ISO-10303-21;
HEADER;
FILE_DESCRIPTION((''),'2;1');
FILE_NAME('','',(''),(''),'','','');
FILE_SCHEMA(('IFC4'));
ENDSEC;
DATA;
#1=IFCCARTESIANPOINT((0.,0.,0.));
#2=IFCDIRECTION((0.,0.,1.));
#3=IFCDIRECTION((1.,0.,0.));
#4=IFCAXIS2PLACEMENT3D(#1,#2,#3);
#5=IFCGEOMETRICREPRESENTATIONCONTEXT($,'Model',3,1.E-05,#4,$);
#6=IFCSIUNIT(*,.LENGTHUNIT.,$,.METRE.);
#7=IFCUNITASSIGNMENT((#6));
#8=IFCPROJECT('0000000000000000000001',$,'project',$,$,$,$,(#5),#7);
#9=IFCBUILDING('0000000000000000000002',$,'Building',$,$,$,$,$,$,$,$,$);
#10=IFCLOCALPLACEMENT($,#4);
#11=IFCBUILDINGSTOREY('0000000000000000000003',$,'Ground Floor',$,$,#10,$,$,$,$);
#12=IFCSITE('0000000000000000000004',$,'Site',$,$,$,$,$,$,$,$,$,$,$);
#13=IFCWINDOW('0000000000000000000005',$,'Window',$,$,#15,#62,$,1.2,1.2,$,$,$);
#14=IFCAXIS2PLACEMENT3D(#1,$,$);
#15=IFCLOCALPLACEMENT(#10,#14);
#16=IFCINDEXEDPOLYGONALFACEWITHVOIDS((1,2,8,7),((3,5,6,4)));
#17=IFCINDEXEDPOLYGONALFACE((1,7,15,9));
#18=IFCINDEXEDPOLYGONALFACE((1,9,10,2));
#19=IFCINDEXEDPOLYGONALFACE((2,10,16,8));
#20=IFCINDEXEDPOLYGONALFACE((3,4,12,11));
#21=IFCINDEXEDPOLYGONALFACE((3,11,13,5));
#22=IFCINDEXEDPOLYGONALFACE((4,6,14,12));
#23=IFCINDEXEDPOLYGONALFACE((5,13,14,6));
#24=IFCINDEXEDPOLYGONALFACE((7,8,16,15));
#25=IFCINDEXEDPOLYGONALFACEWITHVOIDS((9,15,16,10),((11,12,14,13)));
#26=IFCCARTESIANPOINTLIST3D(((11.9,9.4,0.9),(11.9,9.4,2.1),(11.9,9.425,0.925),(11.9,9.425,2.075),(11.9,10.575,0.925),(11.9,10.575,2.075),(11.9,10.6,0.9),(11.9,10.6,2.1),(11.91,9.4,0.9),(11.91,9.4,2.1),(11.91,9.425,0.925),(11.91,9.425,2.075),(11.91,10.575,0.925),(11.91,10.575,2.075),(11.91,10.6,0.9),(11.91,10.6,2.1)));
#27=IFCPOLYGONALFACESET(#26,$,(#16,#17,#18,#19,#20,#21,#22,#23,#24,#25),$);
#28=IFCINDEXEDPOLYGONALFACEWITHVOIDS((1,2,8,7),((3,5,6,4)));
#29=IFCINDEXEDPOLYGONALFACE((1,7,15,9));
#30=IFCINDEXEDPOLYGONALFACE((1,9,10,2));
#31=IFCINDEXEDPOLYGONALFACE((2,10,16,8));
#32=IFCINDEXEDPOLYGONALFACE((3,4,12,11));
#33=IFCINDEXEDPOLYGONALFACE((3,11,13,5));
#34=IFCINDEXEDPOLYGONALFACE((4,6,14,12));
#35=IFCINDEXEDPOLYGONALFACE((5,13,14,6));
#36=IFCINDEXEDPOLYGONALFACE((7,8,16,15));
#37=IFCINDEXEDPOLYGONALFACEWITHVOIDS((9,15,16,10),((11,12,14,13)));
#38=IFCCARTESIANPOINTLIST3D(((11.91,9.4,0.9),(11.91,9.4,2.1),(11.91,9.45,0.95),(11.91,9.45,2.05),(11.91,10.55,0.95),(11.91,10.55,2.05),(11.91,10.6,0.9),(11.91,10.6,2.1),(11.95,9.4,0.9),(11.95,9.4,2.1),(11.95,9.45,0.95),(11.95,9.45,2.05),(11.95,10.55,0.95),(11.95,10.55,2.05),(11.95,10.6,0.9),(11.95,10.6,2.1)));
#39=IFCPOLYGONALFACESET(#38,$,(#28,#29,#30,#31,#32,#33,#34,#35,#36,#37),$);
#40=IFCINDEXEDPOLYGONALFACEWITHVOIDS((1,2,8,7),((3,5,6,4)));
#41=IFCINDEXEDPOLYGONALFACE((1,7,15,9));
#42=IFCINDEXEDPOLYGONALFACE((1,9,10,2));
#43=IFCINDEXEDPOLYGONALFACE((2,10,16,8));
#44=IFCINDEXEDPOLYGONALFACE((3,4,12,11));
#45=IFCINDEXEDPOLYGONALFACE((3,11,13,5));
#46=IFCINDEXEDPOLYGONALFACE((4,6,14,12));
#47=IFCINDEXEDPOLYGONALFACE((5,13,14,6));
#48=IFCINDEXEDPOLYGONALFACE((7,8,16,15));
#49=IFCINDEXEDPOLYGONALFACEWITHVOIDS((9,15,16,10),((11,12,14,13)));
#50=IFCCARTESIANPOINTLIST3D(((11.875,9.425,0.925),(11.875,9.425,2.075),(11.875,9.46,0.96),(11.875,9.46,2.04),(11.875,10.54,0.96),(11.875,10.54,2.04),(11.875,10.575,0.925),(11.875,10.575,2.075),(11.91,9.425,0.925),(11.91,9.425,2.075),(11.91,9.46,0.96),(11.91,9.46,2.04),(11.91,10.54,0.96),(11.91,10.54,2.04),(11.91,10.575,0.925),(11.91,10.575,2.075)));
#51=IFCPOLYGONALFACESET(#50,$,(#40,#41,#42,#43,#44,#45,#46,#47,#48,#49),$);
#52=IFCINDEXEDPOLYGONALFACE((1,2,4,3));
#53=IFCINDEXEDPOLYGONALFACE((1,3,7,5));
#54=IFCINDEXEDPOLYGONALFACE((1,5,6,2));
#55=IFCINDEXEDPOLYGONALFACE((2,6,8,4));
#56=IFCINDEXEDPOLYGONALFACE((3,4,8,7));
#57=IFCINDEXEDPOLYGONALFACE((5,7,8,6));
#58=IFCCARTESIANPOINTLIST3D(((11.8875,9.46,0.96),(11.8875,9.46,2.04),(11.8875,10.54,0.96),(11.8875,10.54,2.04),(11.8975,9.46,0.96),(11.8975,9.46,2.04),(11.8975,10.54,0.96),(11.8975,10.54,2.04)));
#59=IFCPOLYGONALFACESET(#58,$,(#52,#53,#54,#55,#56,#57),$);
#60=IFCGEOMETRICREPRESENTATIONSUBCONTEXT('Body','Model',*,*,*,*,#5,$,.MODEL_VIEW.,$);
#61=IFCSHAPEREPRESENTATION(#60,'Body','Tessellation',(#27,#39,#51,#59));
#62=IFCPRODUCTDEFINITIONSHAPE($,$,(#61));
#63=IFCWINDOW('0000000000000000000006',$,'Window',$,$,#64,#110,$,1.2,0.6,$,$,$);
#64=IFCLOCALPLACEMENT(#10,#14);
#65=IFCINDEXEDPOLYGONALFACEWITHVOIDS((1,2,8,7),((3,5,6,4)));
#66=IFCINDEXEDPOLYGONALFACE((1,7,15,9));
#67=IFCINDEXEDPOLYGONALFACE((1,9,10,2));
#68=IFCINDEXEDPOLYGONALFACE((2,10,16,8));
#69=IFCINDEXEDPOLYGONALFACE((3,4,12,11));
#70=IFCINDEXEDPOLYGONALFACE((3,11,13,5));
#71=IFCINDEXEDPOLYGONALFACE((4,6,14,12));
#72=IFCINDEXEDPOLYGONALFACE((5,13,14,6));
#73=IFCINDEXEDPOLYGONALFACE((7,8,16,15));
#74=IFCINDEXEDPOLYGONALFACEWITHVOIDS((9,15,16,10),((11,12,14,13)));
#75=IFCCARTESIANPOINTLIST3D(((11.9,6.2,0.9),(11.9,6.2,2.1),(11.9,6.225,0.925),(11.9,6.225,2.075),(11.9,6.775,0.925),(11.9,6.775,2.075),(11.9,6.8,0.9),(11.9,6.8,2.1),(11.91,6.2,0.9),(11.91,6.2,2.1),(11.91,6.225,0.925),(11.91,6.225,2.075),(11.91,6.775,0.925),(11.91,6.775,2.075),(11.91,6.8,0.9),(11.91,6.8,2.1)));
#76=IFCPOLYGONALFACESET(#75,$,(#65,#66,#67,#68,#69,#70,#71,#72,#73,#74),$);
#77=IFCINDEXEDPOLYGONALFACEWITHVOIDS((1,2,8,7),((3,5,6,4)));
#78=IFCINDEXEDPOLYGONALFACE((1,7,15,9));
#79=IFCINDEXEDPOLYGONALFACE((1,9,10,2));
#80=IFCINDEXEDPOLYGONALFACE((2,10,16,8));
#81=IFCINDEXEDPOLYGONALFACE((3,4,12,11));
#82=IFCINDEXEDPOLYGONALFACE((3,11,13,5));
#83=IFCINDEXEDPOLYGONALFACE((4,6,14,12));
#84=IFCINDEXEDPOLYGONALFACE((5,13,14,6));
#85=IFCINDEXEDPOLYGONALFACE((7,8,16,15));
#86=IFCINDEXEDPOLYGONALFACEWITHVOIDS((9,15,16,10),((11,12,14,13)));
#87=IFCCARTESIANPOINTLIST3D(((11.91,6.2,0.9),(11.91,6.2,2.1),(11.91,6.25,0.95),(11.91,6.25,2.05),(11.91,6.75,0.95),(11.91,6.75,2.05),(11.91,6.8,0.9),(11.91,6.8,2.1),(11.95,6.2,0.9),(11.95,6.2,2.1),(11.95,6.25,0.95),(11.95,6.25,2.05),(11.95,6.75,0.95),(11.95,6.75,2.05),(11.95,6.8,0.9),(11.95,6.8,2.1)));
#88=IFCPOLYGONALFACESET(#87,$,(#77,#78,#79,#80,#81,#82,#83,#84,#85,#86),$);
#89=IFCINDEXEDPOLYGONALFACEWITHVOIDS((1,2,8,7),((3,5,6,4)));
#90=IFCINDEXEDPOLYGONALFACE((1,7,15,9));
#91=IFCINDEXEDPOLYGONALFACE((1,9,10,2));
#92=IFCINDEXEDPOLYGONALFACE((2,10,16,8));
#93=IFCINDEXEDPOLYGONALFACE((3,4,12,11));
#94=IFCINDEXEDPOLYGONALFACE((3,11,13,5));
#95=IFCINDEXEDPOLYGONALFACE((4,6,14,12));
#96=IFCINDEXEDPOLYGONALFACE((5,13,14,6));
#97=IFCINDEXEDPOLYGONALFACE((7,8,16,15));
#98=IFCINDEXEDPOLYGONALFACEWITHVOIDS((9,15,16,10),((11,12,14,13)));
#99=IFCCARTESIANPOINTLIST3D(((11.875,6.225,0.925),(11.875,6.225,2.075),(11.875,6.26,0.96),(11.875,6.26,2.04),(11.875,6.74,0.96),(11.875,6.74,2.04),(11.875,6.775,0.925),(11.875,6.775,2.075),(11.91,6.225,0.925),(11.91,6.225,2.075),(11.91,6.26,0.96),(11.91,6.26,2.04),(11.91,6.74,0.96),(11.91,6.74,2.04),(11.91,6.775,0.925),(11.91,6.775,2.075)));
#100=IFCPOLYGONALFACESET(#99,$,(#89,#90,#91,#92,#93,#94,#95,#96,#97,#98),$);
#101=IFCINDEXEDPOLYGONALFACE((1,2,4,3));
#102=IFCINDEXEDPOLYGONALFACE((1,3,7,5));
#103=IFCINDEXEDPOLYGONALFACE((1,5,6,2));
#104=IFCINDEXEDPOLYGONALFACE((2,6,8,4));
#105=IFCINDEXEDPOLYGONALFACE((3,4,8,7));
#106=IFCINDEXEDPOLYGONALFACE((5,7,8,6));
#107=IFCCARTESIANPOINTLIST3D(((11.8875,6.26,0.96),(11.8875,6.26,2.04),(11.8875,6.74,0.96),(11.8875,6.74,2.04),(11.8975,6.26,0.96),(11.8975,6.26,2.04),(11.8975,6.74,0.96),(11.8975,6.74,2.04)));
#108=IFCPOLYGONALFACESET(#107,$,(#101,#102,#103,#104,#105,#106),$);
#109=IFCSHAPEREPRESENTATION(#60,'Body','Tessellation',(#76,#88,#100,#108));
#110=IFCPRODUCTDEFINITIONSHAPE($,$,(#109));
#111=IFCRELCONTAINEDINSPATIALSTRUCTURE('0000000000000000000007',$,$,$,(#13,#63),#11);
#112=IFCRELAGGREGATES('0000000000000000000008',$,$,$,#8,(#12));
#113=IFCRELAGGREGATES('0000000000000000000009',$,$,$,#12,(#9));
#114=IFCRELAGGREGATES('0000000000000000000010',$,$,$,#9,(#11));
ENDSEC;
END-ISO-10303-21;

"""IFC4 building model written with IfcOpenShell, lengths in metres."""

from ifc_helpers import new_model, si_unit, frame, origin_with_axes, place, context, subcontext, project, spatial, line, indexed_curve, outline, extrude, element, save


model = new_model("IFC4")

# Units and contexts
model_context = context("Model", 3, precision=1e-05, world=origin_with_axes())
body_context = subcontext(model_context, "Body", "Model", "MODEL_VIEW")
ifc_project = project(units=[si_unit("LENGTHUNIT", "METRE")], contexts=[model_context])

# Site, building, storey
site = spatial("IfcSite", under=ifc_project, Name="Site")
building = spatial("IfcBuilding", under=site, Name="Building")
storey_placement = place(None, origin_with_axes())
storey = spatial("IfcBuildingStorey", under=building, at=storey_placement, Name="Ground Floor")

# Windows
for number, where, z_axis, x_axis, name in (
    (1, (12.0, 9.4, 0.9), (0.0, 0.0, 1.0), (0.0, 1.0, 0.0), "Window"),
):
    element("IfcWindow", number, at=place(storey_placement, frame(where, z_axis=z_axis, x_axis=x_axis)), inside=storey, Name=name, OverallHeight=1.2, OverallWidth=1.2, context=body_context, shape_type="SweptSolid", body=[
        extrude(outline(indexed_curve([(0.0, 0.0), (1.2, 0.0), (1.2, 1.2), (0.0, 1.2)], segments=[line(1, 2, 3, 4, 1)]), holes=[indexed_curve([(0.025, 0.025), (1.175, 0.025), (1.175, 1.175), (0.025, 1.175)], segments=[line(1, 2, 3, 4, 1)])]), frame((0.0, 0.09, 0.0), z_axis=(0.0, -1.0, 0.0), x_axis=(1.0, 0.0, 0.0)), (0.0, 0.0, -1.0), 0.01),
        extrude(outline(indexed_curve([(0.0, 0.0), (1.2, 0.0), (1.2, 1.2), (0.0, 1.2)], segments=[line(1, 2, 3, 4, 1)]), holes=[indexed_curve([(0.05, 0.05), (1.15, 0.05), (1.15, 1.15), (0.05, 1.15)], segments=[line(1, 2, 3, 4, 1)])]), frame((0.0, 0.05, 0.0), z_axis=(0.0, -1.0, 0.0), x_axis=(1.0, 0.0, 0.0)), (0.0, 0.0, -1.0), 0.04),
        extrude(outline(indexed_curve([(0.0, 0.0), (1.15, 0.0), (1.15, 1.15), (0.0, 1.15)], segments=[line(1, 2, 3, 4, 1)]), holes=[indexed_curve([(0.035, 0.035), (1.115, 0.035), (1.115, 1.115), (0.035, 1.115)], segments=[line(1, 2, 3, 4, 1)])]), frame((0.025, 0.09, 0.025), z_axis=(0.0, -1.0, 0.0), x_axis=(1.0, 0.0, 0.0)), (0.0, 0.0, -1.0), 0.035),
        extrude(outline(indexed_curve([(0.035, 0.035), (1.115, 0.035), (1.115, 1.115), (0.035, 1.115)], segments=[line(1, 2, 3, 4, 1)])), frame((0.025, 0.1025, 0.025), z_axis=(0.0, -1.0, 0.0), x_axis=(1.0, 0.0, 0.0)), (0.0, 0.0, -1.0), 0.01),
    ])
window_placement = place(storey_placement, frame((12.0, 6.2, 0.9), z_axis=(0.0, 0.0, 1.0), x_axis=(0.0, 1.0, 0.0)))
element("IfcWindow", 2, at=window_placement, inside=storey, Name="Window", OverallHeight=1.2, OverallWidth=0.6, context=body_context, shape_type="SweptSolid", body=[
    extrude(outline(indexed_curve([(0.0, 0.0), (0.6, 0.0), (0.6, 1.2), (0.0, 1.2)], segments=[line(1, 2, 3, 4, 1)]), holes=[indexed_curve([(0.025, 0.025), (0.575, 0.025), (0.575, 1.175), (0.025, 1.175)], segments=[line(1, 2, 3, 4, 1)])]), frame((0.0, 0.09, 0.0), z_axis=(0.0, -1.0, 0.0), x_axis=(1.0, 0.0, 0.0)), (0.0, 0.0, -1.0), 0.01),
    extrude(outline(indexed_curve([(0.0, 0.0), (0.6, 0.0), (0.6, 1.2), (0.0, 1.2)], segments=[line(1, 2, 3, 4, 1)]), holes=[indexed_curve([(0.05, 0.05), (0.55, 0.05), (0.55, 1.15), (0.05, 1.15)], segments=[line(1, 2, 3, 4, 1)])]), frame((0.0, 0.05, 0.0), z_axis=(0.0, -1.0, 0.0), x_axis=(1.0, 0.0, 0.0)), (0.0, 0.0, -1.0), 0.04),
    extrude(outline(indexed_curve([(0.0, 0.0), (0.55, 0.0), (0.55, 1.15), (0.0, 1.15)], segments=[line(1, 2, 3, 4, 1)]), holes=[indexed_curve([(0.035, 0.035), (0.515, 0.035), (0.515, 1.115), (0.035, 1.115)], segments=[line(1, 2, 3, 4, 1)])]), frame((0.025, 0.09, 0.025), z_axis=(0.0, -1.0, 0.0), x_axis=(1.0, 0.0, 0.0)), (0.0, 0.0, -1.0), 0.035),
    extrude(outline(indexed_curve([(0.035, 0.035), (0.515, 0.035), (0.515, 1.115), (0.035, 1.115)], segments=[line(1, 2, 3, 4, 1)])), frame((0.025, 0.1025, 0.025), z_axis=(0.0, -1.0, 0.0), x_axis=(1.0, 0.0, 0.0)), (0.0, 0.0, -1.0), 0.01),
])

save(model, "model.ifc")
